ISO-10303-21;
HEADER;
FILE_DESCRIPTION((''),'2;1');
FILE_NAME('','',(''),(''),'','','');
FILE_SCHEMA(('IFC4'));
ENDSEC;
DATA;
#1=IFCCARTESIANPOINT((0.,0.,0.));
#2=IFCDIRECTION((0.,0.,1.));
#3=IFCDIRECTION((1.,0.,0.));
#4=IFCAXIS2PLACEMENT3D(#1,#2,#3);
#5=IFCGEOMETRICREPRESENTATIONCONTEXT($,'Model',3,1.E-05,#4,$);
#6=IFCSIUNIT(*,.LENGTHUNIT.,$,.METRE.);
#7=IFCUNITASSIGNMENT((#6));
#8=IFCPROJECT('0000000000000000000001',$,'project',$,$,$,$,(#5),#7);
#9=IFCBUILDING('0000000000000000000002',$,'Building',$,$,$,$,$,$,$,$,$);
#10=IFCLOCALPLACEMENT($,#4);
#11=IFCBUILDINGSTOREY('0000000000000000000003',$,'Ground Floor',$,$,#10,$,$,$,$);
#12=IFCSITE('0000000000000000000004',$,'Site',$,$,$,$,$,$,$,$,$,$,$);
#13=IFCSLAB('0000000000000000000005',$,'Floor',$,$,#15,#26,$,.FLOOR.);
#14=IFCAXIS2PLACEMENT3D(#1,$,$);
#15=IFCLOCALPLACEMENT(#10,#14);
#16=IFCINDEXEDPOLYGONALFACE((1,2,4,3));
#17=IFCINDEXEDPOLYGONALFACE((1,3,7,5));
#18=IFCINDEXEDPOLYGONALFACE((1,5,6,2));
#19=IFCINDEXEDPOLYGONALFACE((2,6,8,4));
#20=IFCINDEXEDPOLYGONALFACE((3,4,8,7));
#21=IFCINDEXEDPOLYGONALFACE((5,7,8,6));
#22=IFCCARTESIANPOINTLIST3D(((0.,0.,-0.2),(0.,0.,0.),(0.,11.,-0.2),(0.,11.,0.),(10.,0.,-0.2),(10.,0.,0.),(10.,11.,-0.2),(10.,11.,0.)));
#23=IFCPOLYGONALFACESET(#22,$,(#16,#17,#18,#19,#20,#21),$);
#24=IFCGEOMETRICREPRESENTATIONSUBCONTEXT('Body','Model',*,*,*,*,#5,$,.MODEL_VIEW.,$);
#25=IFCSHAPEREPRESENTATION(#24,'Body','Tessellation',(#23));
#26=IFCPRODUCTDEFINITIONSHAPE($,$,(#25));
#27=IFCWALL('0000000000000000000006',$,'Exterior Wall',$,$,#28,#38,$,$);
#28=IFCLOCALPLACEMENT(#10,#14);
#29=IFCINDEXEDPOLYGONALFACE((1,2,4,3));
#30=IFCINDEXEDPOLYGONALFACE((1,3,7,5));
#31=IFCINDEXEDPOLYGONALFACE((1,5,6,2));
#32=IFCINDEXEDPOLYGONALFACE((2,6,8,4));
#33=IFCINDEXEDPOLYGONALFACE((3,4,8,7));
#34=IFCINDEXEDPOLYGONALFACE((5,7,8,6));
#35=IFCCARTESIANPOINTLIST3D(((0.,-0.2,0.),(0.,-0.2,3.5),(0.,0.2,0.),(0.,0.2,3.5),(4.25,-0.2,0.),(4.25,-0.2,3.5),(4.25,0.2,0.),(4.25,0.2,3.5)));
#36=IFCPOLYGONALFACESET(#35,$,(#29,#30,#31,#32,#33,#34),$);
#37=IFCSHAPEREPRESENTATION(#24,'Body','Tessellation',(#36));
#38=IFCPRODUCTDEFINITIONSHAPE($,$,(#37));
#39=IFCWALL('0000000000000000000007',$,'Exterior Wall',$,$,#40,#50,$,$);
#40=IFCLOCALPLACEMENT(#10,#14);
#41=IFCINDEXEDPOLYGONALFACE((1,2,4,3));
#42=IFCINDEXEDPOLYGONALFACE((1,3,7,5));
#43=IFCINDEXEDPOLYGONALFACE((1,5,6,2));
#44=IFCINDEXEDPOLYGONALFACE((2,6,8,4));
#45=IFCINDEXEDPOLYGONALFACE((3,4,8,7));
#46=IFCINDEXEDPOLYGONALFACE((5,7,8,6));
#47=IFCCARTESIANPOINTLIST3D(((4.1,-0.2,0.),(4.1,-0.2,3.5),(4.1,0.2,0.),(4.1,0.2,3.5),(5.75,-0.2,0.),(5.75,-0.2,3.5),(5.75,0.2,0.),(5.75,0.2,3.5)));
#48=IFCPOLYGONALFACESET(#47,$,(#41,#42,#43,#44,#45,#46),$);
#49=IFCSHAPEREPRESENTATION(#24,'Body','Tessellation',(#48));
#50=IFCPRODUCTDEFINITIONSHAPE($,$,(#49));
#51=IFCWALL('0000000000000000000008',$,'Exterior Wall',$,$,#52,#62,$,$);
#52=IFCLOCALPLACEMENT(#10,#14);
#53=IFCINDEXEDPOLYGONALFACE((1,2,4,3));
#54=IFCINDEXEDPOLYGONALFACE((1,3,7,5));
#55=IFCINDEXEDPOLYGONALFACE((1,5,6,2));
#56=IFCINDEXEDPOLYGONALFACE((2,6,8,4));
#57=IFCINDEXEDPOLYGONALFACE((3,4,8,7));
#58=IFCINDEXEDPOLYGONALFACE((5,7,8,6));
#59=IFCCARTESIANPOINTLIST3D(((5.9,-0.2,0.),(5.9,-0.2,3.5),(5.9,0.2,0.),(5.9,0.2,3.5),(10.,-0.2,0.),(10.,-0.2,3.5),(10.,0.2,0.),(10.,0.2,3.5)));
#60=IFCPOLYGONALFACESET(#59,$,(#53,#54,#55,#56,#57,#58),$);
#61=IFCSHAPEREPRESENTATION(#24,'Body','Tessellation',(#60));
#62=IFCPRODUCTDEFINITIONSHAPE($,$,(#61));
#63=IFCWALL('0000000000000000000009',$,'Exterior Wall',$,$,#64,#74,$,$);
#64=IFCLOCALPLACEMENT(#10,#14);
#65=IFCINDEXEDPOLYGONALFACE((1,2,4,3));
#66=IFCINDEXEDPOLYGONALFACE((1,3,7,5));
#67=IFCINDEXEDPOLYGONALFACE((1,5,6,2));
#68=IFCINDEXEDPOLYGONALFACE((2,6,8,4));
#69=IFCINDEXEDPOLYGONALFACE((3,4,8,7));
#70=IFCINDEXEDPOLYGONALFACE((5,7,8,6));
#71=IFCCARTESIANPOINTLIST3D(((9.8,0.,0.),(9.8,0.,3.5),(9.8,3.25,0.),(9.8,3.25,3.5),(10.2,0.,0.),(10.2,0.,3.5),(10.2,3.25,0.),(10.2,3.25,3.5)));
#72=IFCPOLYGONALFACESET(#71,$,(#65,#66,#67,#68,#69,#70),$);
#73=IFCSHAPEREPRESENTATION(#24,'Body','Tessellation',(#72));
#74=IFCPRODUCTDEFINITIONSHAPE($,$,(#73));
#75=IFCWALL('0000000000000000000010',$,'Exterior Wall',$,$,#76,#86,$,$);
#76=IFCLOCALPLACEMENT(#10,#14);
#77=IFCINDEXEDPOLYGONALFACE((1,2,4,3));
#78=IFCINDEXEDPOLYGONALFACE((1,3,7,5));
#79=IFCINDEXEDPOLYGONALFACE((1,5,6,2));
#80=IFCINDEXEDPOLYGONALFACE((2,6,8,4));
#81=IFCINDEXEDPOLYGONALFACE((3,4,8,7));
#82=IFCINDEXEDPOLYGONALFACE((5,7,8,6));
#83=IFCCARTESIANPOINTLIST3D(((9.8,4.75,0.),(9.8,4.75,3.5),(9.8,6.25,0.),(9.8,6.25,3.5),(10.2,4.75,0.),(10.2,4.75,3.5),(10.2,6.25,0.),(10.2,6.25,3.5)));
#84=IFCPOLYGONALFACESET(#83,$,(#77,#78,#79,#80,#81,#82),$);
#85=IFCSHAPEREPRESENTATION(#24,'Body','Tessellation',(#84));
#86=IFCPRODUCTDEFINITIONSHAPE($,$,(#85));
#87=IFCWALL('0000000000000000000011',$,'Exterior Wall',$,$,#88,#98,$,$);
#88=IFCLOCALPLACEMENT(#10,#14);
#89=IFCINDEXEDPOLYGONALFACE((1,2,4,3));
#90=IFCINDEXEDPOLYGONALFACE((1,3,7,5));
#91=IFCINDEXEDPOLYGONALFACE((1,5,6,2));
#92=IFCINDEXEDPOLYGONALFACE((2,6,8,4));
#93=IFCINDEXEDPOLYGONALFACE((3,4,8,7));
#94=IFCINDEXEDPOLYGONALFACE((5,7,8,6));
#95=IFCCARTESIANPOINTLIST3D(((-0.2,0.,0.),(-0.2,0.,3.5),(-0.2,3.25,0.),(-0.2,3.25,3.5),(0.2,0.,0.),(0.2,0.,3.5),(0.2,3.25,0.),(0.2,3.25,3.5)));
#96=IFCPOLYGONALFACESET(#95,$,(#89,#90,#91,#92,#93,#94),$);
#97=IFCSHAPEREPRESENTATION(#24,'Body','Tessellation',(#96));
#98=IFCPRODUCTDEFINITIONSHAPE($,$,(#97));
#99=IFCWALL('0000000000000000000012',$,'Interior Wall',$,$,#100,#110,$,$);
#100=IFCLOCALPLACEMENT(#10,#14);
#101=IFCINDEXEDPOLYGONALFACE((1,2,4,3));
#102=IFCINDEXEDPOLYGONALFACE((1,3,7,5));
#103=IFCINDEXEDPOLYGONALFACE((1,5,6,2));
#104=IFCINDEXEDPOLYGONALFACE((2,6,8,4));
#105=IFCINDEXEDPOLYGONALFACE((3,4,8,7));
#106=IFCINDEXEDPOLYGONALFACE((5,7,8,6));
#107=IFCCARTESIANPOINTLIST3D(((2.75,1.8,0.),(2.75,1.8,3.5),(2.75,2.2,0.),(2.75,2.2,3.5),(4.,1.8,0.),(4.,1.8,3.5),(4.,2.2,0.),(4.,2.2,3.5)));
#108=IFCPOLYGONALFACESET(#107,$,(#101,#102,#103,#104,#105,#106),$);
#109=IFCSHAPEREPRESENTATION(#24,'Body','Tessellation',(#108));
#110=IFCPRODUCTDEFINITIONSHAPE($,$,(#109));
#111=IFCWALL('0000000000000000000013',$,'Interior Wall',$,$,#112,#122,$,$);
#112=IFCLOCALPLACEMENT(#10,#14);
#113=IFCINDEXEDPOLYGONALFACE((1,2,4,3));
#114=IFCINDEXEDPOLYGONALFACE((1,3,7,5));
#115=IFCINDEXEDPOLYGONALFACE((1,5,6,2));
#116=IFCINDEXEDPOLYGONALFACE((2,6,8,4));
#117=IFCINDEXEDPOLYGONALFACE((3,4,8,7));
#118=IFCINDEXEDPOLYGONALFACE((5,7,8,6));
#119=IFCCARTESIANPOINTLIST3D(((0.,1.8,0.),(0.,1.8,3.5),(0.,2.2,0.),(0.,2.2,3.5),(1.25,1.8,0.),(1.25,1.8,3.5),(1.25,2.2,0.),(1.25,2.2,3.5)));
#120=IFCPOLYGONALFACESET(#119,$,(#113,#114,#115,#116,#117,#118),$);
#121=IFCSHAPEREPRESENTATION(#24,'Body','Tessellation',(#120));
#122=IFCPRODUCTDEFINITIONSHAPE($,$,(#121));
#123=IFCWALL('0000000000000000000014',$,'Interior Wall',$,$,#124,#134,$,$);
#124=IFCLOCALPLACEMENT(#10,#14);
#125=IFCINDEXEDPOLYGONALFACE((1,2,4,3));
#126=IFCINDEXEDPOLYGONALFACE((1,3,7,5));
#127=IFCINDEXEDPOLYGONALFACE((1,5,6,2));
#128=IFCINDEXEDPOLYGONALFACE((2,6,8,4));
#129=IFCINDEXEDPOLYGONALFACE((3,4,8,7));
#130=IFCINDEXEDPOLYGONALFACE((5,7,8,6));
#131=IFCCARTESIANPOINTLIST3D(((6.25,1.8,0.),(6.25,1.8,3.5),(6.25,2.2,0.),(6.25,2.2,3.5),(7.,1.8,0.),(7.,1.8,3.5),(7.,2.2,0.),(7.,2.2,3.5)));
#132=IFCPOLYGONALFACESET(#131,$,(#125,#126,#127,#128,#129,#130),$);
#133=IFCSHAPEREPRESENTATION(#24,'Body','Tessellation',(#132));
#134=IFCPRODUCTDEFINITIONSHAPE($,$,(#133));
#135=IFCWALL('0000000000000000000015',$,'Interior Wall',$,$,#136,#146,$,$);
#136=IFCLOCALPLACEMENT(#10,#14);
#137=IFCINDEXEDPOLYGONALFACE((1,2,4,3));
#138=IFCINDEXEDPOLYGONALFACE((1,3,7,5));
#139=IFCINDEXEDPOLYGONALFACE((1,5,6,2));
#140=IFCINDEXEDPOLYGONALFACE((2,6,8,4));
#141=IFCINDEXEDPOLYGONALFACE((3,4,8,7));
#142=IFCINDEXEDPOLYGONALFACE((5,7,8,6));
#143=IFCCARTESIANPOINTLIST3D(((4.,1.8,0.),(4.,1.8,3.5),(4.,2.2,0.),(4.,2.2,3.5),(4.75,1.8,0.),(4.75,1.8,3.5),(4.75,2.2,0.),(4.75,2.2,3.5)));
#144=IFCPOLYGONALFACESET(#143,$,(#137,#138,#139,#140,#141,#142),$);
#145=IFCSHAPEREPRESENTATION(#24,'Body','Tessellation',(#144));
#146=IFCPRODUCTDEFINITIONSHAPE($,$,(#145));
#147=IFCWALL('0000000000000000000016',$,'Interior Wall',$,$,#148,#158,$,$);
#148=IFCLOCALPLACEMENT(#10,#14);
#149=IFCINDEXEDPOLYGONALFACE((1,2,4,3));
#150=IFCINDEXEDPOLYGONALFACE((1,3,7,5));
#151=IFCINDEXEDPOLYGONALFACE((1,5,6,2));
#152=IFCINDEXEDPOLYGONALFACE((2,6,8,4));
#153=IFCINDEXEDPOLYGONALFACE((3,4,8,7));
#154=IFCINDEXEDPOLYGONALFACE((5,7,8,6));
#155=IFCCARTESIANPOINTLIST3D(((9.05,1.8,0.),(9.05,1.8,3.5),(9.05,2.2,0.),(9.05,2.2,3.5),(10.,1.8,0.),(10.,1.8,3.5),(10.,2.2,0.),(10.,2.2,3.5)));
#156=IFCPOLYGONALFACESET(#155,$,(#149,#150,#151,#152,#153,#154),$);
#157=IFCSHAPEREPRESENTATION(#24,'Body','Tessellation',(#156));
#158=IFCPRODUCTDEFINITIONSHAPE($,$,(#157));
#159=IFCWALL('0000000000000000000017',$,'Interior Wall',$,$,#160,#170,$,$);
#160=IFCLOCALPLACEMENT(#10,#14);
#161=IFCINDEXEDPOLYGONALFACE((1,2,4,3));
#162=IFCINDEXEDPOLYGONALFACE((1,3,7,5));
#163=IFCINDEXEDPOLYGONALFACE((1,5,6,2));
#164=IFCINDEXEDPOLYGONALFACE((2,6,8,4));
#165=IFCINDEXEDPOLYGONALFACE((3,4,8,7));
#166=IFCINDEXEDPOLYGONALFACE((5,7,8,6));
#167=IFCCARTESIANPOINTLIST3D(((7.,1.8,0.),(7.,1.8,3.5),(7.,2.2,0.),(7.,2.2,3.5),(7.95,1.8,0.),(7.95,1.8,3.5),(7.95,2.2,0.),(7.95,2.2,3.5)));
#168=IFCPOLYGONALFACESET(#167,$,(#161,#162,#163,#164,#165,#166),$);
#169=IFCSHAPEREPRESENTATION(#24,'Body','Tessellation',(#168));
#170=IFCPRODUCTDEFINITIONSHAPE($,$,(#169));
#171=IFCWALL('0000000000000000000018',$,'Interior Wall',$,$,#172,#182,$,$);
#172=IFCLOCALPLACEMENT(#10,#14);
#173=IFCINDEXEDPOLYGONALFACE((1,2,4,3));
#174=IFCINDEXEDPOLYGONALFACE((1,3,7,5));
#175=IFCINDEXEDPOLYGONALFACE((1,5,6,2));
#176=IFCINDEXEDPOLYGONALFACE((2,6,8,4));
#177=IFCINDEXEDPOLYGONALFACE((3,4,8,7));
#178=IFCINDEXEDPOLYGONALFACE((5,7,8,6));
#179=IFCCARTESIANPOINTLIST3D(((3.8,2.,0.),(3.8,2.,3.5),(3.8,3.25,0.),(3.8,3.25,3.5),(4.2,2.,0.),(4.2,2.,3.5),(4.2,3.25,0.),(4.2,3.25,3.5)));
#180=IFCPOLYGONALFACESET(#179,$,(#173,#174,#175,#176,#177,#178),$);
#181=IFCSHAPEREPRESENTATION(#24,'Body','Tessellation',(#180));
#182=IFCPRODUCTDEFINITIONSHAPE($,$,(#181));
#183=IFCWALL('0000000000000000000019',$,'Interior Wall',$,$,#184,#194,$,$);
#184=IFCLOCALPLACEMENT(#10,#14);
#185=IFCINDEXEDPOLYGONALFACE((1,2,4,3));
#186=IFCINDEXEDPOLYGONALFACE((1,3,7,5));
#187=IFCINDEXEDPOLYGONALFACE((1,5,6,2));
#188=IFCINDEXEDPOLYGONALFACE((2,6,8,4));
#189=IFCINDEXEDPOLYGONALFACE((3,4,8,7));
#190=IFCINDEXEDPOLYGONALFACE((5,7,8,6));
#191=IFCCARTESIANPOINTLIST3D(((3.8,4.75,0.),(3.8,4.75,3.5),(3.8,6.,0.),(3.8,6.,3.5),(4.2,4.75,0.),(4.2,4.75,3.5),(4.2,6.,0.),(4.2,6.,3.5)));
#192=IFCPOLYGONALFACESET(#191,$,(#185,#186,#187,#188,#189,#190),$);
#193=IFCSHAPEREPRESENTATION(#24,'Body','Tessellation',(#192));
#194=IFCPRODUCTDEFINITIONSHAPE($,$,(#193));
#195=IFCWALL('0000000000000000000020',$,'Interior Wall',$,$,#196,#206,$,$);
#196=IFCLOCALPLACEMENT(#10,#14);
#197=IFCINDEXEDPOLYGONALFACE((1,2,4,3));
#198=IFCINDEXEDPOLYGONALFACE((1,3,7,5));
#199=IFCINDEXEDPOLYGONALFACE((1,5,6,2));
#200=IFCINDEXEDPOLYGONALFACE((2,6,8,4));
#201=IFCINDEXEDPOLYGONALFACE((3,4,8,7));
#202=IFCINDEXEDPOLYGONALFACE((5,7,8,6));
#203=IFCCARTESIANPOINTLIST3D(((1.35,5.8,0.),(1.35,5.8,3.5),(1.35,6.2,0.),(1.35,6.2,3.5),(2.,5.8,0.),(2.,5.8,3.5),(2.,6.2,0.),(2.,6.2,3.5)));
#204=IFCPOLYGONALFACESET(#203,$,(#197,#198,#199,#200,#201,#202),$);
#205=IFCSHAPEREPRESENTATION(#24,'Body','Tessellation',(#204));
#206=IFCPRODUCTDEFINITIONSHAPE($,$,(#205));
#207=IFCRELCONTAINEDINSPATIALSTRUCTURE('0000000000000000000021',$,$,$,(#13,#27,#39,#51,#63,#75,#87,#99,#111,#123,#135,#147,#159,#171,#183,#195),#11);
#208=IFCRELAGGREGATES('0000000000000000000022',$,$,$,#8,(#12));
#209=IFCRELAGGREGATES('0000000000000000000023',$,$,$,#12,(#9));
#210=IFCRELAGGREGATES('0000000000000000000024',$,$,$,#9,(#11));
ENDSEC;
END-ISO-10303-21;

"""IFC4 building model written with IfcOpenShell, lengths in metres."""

from ifc_helpers import new_model, si_unit, frame, origin_with_axes, place, context, subcontext, project, spatial, indexed_curve, outline, extrude, element, save


model = new_model("IFC4")

# Units and contexts
model_context = context("Model", 3, precision=1e-05, world=origin_with_axes())
body_context = subcontext(model_context, "Body", "Model", "MODEL_VIEW")
ifc_project = project(units=[si_unit("LENGTHUNIT", "METRE")], contexts=[model_context])

# Site, building, storey
site = spatial("IfcSite", under=ifc_project, Name="Site")
building = spatial("IfcBuilding", under=site, Name="Building")
storey_placement = place(None, origin_with_axes())
storey = spatial("IfcBuildingStorey", under=building, at=storey_placement, Name="Ground Floor")

# Slab
slab_placement = place(storey_placement, frame((0.0, 0.0, -0.2), z_axis=(0.0, 0.0, 1.0), x_axis=(1.0, 0.0, 0.0)))
element("IfcSlab", 1, at=slab_placement, inside=storey, Name="Floor", PredefinedType="FLOOR", context=body_context, shape_type="SweptSolid", body=[
    extrude(outline(indexed_curve([(0.0, 0.0), (10.0, 0.0), (10.0, 11.0), (0.0, 11.0)])), None, (0.0, 0.0, 1.0), 0.2),
])

# Walls
wall_1_placement = place(storey_placement, origin_with_axes())
element("IfcWall", 2, at=wall_1_placement, inside=storey, Name="Exterior Wall", context=body_context, shape_type="SweptSolid", body=[
    extrude(outline(indexed_curve([(0.0, 0.0), (0.0, 0.4), (4.25, 0.4), (4.25, 0.0), (0.0, 0.0)], self_intersect=False)), frame((0.0, -0.2, 0.0), z_axis=(0.0, 0.0, 1.0), x_axis=(1.0, 0.0, 0.0)), (0.0, 0.0, 1.0), 3.5),
])
wall_2_placement = place(storey_placement, frame((5.75, 0.0, 0.0), z_axis=(0.0, 0.0, 1.0), x_axis=(-1.0, 0.0, 0.0)))
element("IfcWall", 3, at=wall_2_placement, inside=storey, Name="Exterior Wall", context=body_context, shape_type="SweptSolid", body=[
    extrude(outline(indexed_curve([(0.0, 0.0), (0.0, 0.4), (1.65, 0.4), (1.65, 0.0), (0.0, 0.0)], self_intersect=False)), frame((0.0, -0.2, 0.0), z_axis=(0.0, 0.0, 1.0), x_axis=(1.0, 0.0, 0.0)), (0.0, 0.0, 1.0), 3.5),
])
wall_3_placement = place(storey_placement, frame((5.9, 0.0, 0.0), z_axis=(0.0, 0.0, 1.0), x_axis=(1.0, 0.0, 0.0)))
element("IfcWall", 4, at=wall_3_placement, inside=storey, Name="Exterior Wall", context=body_context, shape_type="SweptSolid", body=[
    extrude(outline(indexed_curve([(0.0, 0.0), (0.0, 0.4), (4.1, 0.4), (4.1, 0.0), (0.0, 0.0)], self_intersect=False)), frame((0.0, -0.2, 0.0), z_axis=(0.0, 0.0, 1.0), x_axis=(1.0, 0.0, 0.0)), (0.0, 0.0, 1.0), 3.5),
])
wall_4_placement = place(storey_placement, frame((10.0, 0.0, 0.0), z_axis=(0.0, 0.0, 1.0), x_axis=(0.0, 1.0, 0.0)))
element("IfcWall", 5, at=wall_4_placement, inside=storey, Name="Exterior Wall", context=body_context, shape_type="SweptSolid", body=[
    extrude(outline(indexed_curve([(0.0, 0.0), (0.0, 0.4), (3.25, 0.4), (3.25, 0.0), (0.0, 0.0)], self_intersect=False)), frame((0.0, -0.2, 0.0), z_axis=(0.0, 0.0, 1.0), x_axis=(1.0, 0.0, 0.0)), (0.0, 0.0, 1.0), 3.5),
])
wall_5_placement = place(storey_placement, frame((10.0, 4.75, 0.0), z_axis=(0.0, 0.0, 1.0), x_axis=(0.0, 1.0, 0.0)))
element("IfcWall", 6, at=wall_5_placement, inside=storey, Name="Exterior Wall", context=body_context, shape_type="SweptSolid", body=[
    extrude(outline(indexed_curve([(0.0, 0.0), (0.0, 0.4), (1.5, 0.4), (1.5, 0.0), (0.0, 0.0)], self_intersect=False)), frame((0.0, -0.2, 0.0), z_axis=(0.0, 0.0, 1.0), x_axis=(1.0, 0.0, 0.0)), (0.0, 0.0, 1.0), 3.5),
])
wall_6_placement = place(storey_placement, frame((0.0, 3.25, 0.0), z_axis=(0.0, 0.0, 1.0), x_axis=(0.0, -1.0, 0.0)))
element("IfcWall", 7, at=wall_6_placement, inside=storey, Name="Exterior Wall", context=body_context, shape_type="SweptSolid", body=[
    extrude(outline(indexed_curve([(0.0, 0.0), (0.0, 0.4), (3.25, 0.4), (3.25, 0.0), (0.0, 0.0)], self_intersect=False)), frame((0.0, -0.2, 0.0), z_axis=(0.0, 0.0, 1.0), x_axis=(1.0, 0.0, 0.0)), (0.0, 0.0, 1.0), 3.5),
])
for number, where, z_axis, x_axis, name in (
    (8, (4.0, 2.0, 0.0), (0.0, 0.0, 1.0), (-1.0, 0.0, 0.0), "Interior Wall"),
    (9, (1.25, 2.0, 0.0), (0.0, 0.0, 1.0), (-1.0, 0.0, 0.0), "Interior Wall"),
):
    element("IfcWall", number, at=place(storey_placement, frame(where, z_axis=z_axis, x_axis=x_axis)), inside=storey, Name=name, context=body_context, shape_type="SweptSolid", body=[
        extrude(outline(indexed_curve([(0.0, 0.0), (0.0, 0.4), (1.25, 0.4), (1.25, 0.0), (0.0, 0.0)], self_intersect=False)), frame((0.0, -0.2, 0.0), z_axis=(0.0, 0.0, 1.0), x_axis=(1.0, 0.0, 0.0)), (0.0, 0.0, 1.0), 3.5),
    ])
for number, where, z_axis, x_axis, name in (
    (10, (7.0, 2.0, 0.0), (0.0, 0.0, 1.0), (-1.0, 0.0, 0.0), "Interior Wall"),
    (11, (4.75, 2.0, 0.0), (0.0, 0.0, 1.0), (-1.0, 0.0, 0.0), "Interior Wall"),
):
    element("IfcWall", number, at=place(storey_placement, frame(where, z_axis=z_axis, x_axis=x_axis)), inside=storey, Name=name, context=body_context, shape_type="SweptSolid", body=[
        extrude(outline(indexed_curve([(0.0, 0.0), (0.0, 0.4), (0.75, 0.4), (0.75, 0.0), (0.0, 0.0)], self_intersect=False)), frame((0.0, -0.2, 0.0), z_axis=(0.0, 0.0, 1.0), x_axis=(1.0, 0.0, 0.0)), (0.0, 0.0, 1.0), 3.5),
    ])
wall_7_placement = place(storey_placement, frame((10.0, 2.0, 0.0), z_axis=(0.0, 0.0, 1.0), x_axis=(-1.0, 0.0, 0.0)))
element("IfcWall", 12, at=wall_7_placement, inside=storey, Name="Interior Wall", context=body_context, shape_type="SweptSolid", body=[
    extrude(outline(indexed_curve([(0.0, 0.0), (0.0, 0.4), (0.95, 0.4), (0.95, 0.0), (0.0, 0.0)], self_intersect=False)), frame((0.0, -0.2, 0.0), z_axis=(0.0, 0.0, 1.0), x_axis=(1.0, 0.0, 0.0)), (0.0, 0.0, 1.0), 3.5),
])
wall_8_placement = place(storey_placement, frame((7.95, 2.0, 0.0), z_axis=(0.0, 0.0, 1.0), x_axis=(-1.0, 0.0, 0.0)))
element("IfcWall", 13, at=wall_8_placement, inside=storey, Name="Interior Wall", context=body_context, shape_type="SweptSolid", body=[
    extrude(outline(indexed_curve([(0.0, 0.0), (0.0, 0.4), (0.95, 0.4), (0.95, 0.0), (0.0, 0.0)], self_intersect=False)), frame((0.0, -0.2, 0.0), z_axis=(0.0, 0.0, 1.0), x_axis=(1.0, 0.0, 0.0)), (0.0, 0.0, 1.0), 3.5),
])
for number, where, z_axis, x_axis, name in (
    (14, (4.0, 2.0, 0.0), (0.0, 0.0, 1.0), (0.0, 1.0, 0.0), "Interior Wall"),
    (15, (4.0, 4.75, 0.0), (0.0, 0.0, 1.0), (0.0, 1.0, 0.0), "Interior Wall"),
):
    element("IfcWall", number, at=place(storey_placement, frame(where, z_axis=z_axis, x_axis=x_axis)), inside=storey, Name=name, context=body_context, shape_type="SweptSolid", body=[
        extrude(outline(indexed_curve([(0.0, 0.0), (0.0, 0.4), (1.25, 0.4), (1.25, 0.0), (0.0, 0.0)], self_intersect=False)), frame((0.0, -0.2, 0.0), z_axis=(0.0, 0.0, 1.0), x_axis=(1.0, 0.0, 0.0)), (0.0, 0.0, 1.0), 3.5),
    ])
for number, where, z_axis, x_axis, name in (
    (16, (2.0, 6.0, 0.0), (0.0, 0.0, 1.0), (-1.0, 0.0, 0.0), "Interior Wall"),
):
    element("IfcWall", number, at=place(storey_placement, frame(where, z_axis=z_axis, x_axis=x_axis)), inside=storey, Name=name, context=body_context, shape_type="SweptSolid", body=[
        extrude(outline(indexed_curve([(0.0, 0.0), (0.0, 0.4), (0.65, 0.4), (0.65, 0.0), (0.0, 0.0)], self_intersect=False)), frame((0.0, -0.2, 0.0), z_axis=(0.0, 0.0, 1.0), x_axis=(1.0, 0.0, 0.0)), (0.0, 0.0, 1.0), 3.5),
    ])

save(model, "model.ifc")
